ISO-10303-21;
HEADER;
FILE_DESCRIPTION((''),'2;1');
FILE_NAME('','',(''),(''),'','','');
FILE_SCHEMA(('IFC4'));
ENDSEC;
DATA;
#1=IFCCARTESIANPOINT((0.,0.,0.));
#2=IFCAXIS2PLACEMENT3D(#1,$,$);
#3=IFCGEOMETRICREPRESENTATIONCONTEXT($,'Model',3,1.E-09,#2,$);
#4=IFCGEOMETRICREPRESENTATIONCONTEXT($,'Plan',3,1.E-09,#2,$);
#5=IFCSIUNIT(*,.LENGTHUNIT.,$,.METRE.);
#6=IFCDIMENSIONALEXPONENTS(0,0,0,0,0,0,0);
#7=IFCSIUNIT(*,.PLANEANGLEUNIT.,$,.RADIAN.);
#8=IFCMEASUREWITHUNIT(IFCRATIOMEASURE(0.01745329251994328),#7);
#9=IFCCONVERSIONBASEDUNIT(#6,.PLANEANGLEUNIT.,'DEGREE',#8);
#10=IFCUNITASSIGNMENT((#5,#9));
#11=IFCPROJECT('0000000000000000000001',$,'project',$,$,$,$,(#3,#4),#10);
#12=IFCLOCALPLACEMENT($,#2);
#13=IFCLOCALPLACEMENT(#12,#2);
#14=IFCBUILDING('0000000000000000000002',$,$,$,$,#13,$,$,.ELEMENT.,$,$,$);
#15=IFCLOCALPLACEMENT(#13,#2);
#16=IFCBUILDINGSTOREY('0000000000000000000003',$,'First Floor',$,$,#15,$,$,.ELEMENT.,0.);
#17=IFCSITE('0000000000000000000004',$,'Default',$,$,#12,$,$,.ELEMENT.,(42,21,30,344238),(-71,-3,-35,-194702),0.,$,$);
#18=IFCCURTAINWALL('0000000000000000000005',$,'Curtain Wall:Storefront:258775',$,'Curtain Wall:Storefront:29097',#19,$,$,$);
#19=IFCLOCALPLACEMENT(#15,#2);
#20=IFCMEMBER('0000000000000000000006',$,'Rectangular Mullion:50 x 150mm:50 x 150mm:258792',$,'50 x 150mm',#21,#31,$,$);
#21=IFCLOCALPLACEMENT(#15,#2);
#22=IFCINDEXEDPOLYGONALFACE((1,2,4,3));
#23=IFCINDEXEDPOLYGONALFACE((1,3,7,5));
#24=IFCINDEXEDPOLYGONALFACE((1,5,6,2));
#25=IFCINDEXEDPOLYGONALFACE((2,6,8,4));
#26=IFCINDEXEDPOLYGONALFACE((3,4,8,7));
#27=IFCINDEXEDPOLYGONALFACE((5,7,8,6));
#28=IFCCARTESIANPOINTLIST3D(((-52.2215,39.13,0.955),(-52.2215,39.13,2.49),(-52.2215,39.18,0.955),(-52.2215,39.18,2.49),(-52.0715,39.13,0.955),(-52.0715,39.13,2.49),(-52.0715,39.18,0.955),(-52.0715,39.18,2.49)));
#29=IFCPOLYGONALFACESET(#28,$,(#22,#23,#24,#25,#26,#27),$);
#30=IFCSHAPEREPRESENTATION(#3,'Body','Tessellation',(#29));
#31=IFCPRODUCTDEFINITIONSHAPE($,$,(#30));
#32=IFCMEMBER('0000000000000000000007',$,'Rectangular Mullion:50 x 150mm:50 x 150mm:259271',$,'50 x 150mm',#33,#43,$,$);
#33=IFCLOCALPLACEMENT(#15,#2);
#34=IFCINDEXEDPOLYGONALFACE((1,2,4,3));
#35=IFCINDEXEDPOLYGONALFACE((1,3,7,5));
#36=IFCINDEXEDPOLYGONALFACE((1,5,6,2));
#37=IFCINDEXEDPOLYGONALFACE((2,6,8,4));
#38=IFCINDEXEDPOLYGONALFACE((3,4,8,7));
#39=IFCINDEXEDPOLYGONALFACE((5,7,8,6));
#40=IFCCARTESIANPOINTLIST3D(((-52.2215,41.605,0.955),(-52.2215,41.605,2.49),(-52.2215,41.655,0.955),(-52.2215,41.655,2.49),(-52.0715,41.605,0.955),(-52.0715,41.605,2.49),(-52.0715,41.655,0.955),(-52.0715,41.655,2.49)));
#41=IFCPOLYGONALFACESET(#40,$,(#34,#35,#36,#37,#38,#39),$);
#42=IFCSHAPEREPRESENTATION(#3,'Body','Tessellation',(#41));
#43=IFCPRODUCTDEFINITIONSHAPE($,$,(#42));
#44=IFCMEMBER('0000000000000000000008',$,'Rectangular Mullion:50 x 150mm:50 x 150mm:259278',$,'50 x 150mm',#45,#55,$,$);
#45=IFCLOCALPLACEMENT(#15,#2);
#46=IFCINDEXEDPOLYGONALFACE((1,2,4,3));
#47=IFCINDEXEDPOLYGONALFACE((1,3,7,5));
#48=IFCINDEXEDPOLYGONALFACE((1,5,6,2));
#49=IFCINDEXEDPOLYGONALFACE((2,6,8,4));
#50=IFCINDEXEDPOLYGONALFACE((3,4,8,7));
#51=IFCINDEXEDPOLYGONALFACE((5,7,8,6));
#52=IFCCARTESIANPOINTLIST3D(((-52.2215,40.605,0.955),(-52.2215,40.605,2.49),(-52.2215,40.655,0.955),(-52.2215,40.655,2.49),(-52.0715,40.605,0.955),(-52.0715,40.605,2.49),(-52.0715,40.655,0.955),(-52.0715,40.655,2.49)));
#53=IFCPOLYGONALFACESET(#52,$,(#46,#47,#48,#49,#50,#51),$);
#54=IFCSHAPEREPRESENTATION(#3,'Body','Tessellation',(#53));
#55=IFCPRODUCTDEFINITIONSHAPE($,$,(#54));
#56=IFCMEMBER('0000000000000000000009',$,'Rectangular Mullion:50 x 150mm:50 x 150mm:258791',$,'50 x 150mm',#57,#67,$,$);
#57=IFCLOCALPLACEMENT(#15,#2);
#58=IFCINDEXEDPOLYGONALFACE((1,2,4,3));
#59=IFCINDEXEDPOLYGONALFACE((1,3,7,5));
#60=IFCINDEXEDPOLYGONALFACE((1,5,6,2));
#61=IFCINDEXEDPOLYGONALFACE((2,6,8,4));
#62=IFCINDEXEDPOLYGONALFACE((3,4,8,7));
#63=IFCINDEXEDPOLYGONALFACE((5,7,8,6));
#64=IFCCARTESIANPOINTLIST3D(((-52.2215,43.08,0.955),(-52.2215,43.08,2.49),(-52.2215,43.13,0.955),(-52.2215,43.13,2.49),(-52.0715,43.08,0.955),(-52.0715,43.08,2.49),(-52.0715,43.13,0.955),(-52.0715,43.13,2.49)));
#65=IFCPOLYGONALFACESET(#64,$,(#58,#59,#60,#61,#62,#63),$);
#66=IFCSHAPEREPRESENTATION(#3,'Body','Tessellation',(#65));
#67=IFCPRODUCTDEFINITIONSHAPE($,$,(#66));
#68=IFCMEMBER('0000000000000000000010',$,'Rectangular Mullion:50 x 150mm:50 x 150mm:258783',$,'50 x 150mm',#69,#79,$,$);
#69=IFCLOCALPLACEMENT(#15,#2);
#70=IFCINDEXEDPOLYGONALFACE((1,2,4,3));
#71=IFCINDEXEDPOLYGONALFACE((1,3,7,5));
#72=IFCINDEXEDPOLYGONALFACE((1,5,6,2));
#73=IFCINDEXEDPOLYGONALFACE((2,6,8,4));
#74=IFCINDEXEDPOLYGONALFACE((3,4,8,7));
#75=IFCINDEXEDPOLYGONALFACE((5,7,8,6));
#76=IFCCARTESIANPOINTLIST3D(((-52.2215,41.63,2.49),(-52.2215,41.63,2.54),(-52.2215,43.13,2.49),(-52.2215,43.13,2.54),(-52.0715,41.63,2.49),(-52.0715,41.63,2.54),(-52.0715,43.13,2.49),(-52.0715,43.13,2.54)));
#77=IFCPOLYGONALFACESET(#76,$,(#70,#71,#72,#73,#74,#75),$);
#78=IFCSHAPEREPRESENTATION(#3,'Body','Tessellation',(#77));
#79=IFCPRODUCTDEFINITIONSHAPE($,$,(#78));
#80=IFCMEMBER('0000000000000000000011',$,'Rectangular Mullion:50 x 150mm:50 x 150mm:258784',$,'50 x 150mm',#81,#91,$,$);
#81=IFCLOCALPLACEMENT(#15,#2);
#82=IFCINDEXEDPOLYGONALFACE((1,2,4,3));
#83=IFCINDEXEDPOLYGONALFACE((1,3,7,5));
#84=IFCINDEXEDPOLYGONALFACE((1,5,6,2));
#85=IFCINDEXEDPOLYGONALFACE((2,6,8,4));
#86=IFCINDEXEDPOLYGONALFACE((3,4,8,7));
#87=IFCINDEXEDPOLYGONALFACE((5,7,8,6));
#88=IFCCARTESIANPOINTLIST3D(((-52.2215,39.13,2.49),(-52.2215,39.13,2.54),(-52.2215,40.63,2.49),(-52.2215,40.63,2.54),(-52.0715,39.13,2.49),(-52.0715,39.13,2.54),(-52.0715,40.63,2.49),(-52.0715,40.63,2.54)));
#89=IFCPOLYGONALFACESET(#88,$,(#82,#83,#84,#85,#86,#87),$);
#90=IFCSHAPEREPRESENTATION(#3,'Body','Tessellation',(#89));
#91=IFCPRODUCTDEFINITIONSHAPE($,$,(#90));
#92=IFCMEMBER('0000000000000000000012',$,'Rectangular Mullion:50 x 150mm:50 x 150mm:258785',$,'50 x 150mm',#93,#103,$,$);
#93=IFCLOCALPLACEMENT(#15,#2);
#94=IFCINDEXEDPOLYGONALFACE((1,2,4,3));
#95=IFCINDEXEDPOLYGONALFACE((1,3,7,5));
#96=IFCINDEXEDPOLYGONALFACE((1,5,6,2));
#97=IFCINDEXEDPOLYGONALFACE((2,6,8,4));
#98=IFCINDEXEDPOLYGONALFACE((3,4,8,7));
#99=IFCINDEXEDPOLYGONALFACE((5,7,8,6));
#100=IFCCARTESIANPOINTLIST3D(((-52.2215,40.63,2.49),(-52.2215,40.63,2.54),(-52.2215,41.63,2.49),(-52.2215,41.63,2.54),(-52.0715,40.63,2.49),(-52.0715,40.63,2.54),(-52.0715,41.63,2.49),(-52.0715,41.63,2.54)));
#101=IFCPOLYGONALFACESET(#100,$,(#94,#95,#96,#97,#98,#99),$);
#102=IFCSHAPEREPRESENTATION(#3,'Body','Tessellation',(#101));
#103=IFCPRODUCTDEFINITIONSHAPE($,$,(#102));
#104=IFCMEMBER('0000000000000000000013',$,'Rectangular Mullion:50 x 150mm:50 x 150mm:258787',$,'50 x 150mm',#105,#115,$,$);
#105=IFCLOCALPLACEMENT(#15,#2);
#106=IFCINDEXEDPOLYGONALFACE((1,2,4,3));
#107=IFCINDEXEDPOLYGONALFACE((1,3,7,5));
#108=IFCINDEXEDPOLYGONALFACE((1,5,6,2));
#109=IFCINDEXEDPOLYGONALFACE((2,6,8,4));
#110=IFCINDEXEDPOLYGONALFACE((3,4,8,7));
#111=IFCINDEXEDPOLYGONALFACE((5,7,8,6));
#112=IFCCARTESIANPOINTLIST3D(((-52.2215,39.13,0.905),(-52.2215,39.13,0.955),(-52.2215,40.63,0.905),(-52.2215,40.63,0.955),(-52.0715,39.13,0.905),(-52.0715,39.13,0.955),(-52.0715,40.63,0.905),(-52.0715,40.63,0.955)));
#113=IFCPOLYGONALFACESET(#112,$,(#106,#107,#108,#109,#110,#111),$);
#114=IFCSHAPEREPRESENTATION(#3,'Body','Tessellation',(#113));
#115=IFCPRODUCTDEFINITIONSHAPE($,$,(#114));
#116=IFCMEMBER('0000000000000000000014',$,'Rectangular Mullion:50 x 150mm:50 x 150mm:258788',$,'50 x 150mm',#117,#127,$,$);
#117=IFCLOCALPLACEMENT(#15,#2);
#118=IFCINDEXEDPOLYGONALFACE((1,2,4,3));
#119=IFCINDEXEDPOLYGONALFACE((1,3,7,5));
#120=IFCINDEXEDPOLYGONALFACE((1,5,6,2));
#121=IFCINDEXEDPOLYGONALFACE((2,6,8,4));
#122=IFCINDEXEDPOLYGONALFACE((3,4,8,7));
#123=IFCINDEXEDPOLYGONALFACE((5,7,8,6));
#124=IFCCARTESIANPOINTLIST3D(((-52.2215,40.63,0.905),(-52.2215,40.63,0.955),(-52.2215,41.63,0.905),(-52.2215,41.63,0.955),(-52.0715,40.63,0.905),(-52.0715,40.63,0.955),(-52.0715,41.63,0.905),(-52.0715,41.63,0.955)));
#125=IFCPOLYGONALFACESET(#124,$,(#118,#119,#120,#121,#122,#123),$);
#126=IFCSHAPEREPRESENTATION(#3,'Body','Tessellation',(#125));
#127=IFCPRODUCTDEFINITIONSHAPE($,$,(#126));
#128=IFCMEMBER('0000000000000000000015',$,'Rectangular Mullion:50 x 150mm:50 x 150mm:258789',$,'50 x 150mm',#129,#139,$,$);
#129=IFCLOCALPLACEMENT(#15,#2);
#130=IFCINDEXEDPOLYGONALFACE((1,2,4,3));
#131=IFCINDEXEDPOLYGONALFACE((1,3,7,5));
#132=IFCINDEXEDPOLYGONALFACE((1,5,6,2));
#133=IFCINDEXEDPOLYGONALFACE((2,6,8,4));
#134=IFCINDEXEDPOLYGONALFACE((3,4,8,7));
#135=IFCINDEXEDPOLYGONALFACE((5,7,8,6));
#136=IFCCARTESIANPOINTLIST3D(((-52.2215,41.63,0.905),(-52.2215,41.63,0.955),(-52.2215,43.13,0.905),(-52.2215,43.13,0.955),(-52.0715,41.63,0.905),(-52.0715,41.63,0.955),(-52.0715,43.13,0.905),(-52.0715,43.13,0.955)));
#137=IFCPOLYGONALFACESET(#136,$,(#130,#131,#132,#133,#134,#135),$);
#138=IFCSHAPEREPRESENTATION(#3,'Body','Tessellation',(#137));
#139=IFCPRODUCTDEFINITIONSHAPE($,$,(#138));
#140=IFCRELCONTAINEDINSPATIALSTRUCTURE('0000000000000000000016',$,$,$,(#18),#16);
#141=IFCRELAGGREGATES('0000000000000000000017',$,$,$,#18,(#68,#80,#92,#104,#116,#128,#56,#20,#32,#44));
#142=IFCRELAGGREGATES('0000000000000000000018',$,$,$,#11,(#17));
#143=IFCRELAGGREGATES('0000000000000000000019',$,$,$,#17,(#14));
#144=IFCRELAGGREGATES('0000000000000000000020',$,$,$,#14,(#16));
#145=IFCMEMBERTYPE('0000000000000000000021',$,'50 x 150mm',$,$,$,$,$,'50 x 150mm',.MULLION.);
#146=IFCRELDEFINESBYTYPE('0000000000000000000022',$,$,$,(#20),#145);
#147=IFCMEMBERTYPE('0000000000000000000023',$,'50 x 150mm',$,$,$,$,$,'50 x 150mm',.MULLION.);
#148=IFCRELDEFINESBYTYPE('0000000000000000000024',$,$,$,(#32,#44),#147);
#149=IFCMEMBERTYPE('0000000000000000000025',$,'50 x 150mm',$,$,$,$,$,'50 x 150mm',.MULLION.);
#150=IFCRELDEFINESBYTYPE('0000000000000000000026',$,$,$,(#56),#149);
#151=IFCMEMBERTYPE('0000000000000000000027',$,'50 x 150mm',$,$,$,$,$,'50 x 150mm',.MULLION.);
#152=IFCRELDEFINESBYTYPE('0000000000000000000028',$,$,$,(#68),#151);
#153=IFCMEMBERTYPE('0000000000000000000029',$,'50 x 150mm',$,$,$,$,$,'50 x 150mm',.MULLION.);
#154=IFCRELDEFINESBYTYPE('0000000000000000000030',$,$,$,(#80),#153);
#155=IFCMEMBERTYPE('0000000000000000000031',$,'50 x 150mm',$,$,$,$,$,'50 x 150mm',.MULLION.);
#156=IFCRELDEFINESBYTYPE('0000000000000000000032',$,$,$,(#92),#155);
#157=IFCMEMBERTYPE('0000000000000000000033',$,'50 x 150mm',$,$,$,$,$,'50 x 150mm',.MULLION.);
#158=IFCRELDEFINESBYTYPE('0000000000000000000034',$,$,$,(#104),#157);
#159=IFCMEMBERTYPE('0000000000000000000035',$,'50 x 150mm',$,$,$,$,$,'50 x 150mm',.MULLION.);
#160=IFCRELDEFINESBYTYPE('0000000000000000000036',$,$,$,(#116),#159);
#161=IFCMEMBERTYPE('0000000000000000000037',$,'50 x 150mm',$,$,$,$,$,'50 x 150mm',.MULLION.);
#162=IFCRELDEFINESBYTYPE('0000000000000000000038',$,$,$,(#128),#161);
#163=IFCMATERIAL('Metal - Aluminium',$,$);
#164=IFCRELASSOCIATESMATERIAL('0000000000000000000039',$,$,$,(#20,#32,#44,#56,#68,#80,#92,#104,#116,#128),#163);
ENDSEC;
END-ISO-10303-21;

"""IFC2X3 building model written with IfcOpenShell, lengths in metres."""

from ifc_helpers import new_model, entity, si_unit, converted_unit, frame, origin, origin_2d_with_axis, place, context, project, spatial, rectangle, extrude, source, transform, mapped, material, type_object, type_shapes, element, aggregate, save


model = new_model("IFC2X3")

# Units and contexts
model_context = context("Model", 3, precision=1e-09, world=origin())
plan_context = context("Plan", 3, precision=1e-09, world=origin())
ifc_project = project(units=[si_unit("LENGTHUNIT", "METRE"), converted_unit("PLANEANGLEUNIT", "DEGREE", entity("IfcRatioMeasure", 0.01745329251994328), si_unit("PLANEANGLEUNIT", "RADIAN"), dimensions=[0, 0, 0, 0, 0, 0, 0])], contexts=[model_context, plan_context])

# Site, building, storey
site_placement = place(None, origin())
site = spatial("IfcSite", under=ifc_project, at=site_placement, Name="Default", CompositionType="ELEMENT", RefLatitude=(42, 21, 30, 344238), RefLongitude=(-71, -3, -35, -194702), RefElevation=0.0)
building_placement = place(site_placement, origin())
building = spatial("IfcBuilding", under=site, at=building_placement, CompositionType="ELEMENT")
storey_placement = place(building_placement, origin())
storey = spatial("IfcBuildingStorey", under=building, at=storey_placement, Name="First Floor", CompositionType="ELEMENT", Elevation=0.0)

# Curtain wall, members
curtain_wall_placement = place(storey_placement, origin())
curtain_wall = element("IfcCurtainWall", 1, at=curtain_wall_placement, inside=storey, Name="Curtain Wall:Storefront:258775", ObjectType="Curtain Wall:Storefront:29097")
ifc_material_1 = material(Name="Metal - Aluminium")
member_type_1 = type_object("IfcMemberType", Name="50 x 150mm", ElementType="50 x 150mm", PredefinedType="MULLION")
shared_shape_1 = source(origin(), model_context, "Body", "SweptSolid", [
    extrude(rectangle(XDim=0.05, YDim=0.15, at=origin_2d_with_axis()), frame((-0.025, 0.0, -1.535), z_axis=(0.0, 0.0, 1.0), x_axis=(-1.0, 0.0, 0.0)), (0.0, 0.0, 1.0), 1.535),
])
type_shapes(member_type_1, [shared_shape_1])
member_1_placement = place(storey_placement, frame((-52.1465, 39.13, 2.49), z_axis=(0.0, 0.0, 1.0), x_axis=(0.0, -1.0, 0.0)))
member_1 = element("IfcMember", 2, at=member_1_placement, type_object=member_type_1, material=ifc_material_1, Name="Rectangular Mullion:50 x 150mm:50 x 150mm:258792", ObjectType="50 x 150mm", context=model_context, shape_type="MappedRepresentation", body=[
    mapped(shared_shape_1, transform((0.0, 0.0, 0.0), scale=1.0)),
])
member_type_2 = type_object("IfcMemberType", Name="50 x 150mm", ElementType="50 x 150mm", PredefinedType="MULLION")
shared_shape_2 = source(origin(), model_context, "Body", "SweptSolid", [
    extrude(rectangle(XDim=0.05, YDim=0.15, at=origin_2d_with_axis()), frame((0.0, 0.0, -1.535), z_axis=(0.0, 0.0, 1.0), x_axis=(-1.0, 0.0, 0.0)), (0.0, 0.0, 1.0), 1.535),
])
type_shapes(member_type_2, [shared_shape_2])
member_2_placement = place(storey_placement, frame((-52.1465, 41.63, 0.955), z_axis=(0.0, 0.0, -1.0), x_axis=(0.0, 1.0, 0.0)))
member_2 = element("IfcMember", 3, at=member_2_placement, type_object=member_type_2, material=ifc_material_1, Name="Rectangular Mullion:50 x 150mm:50 x 150mm:259271", ObjectType="50 x 150mm", context=model_context, shape_type="MappedRepresentation", body=[
    mapped(shared_shape_2, transform((0.0, 0.0, 0.0), scale=1.0)),
])
member_3_placement = place(storey_placement, frame((-52.1465, 40.63, 0.955), z_axis=(0.0, 0.0, -1.0), x_axis=(0.0, 1.0, 0.0)))
member_3 = element("IfcMember", 4, at=member_3_placement, type_object=member_type_2, material=ifc_material_1, Name="Rectangular Mullion:50 x 150mm:50 x 150mm:259278", ObjectType="50 x 150mm", context=model_context, shape_type="MappedRepresentation", body=[
    mapped(shared_shape_2, transform((0.0, 0.0, 0.0), scale=1.0)),
])
member_type_3 = type_object("IfcMemberType", Name="50 x 150mm", ElementType="50 x 150mm", PredefinedType="MULLION")
shared_shape_3 = source(origin(), model_context, "Body", "SweptSolid", [
    extrude(rectangle(XDim=0.05, YDim=0.15, at=origin_2d_with_axis()), frame((-0.025, 0.0, -1.535), z_axis=(0.0, 0.0, 1.0), x_axis=(-1.0, 0.0, 0.0)), (0.0, 0.0, 1.0), 1.535),
])
type_shapes(member_type_3, [shared_shape_3])
member_4_placement = place(storey_placement, frame((-52.1465, 43.13, 0.955), z_axis=(0.0, 0.0, -1.0), x_axis=(0.0, 1.0, 0.0)))
member_4 = element("IfcMember", 5, at=member_4_placement, type_object=member_type_3, material=ifc_material_1, Name="Rectangular Mullion:50 x 150mm:50 x 150mm:258791", ObjectType="50 x 150mm", context=model_context, shape_type="MappedRepresentation", body=[
    mapped(shared_shape_3, transform((0.0, 0.0, 0.0), scale=1.0)),
])
member_type_4 = type_object("IfcMemberType", Name="50 x 150mm", ElementType="50 x 150mm", PredefinedType="MULLION")
shared_shape_4 = source(origin(), model_context, "Body", "SweptSolid", [
    extrude(rectangle(XDim=0.05, YDim=0.15, at=origin_2d_with_axis()), frame((-0.025, 0.0, -1.5), z_axis=(0.0, 0.0, 1.0), x_axis=(-1.0, 0.0, 0.0)), (0.0, 0.0, 1.0), 1.5),
])
type_shapes(member_type_4, [shared_shape_4])
member_5_placement = place(storey_placement, frame((-52.1465, 43.13, 2.54), z_axis=(0.0, 1.0, 0.0), x_axis=(0.0, 0.0, 1.0)))
member_5 = element("IfcMember", 6, at=member_5_placement, type_object=member_type_4, material=ifc_material_1, Name="Rectangular Mullion:50 x 150mm:50 x 150mm:258783", ObjectType="50 x 150mm", context=model_context, shape_type="MappedRepresentation", body=[
    mapped(shared_shape_4, transform((0.0, 0.0, 0.0), scale=1.0)),
])
member_type_5 = type_object("IfcMemberType", Name="50 x 150mm", ElementType="50 x 150mm", PredefinedType="MULLION")
shared_shape_5 = source(origin(), model_context, "Body", "SweptSolid", [
    extrude(rectangle(XDim=0.05, YDim=0.15, at=origin_2d_with_axis()), frame((-0.025, 0.0, -1.5), z_axis=(0.0, 0.0, 1.0), x_axis=(-1.0, 0.0, 0.0)), (0.0, 0.0, 1.0), 1.5),
])
type_shapes(member_type_5, [shared_shape_5])
member_6_placement = place(storey_placement, frame((-52.1465, 40.63, 2.54), z_axis=(0.0, 1.0, 0.0), x_axis=(0.0, 0.0, 1.0)))
member_6 = element("IfcMember", 7, at=member_6_placement, type_object=member_type_5, material=ifc_material_1, Name="Rectangular Mullion:50 x 150mm:50 x 150mm:258784", ObjectType="50 x 150mm", context=model_context, shape_type="MappedRepresentation", body=[
    mapped(shared_shape_5, transform((0.0, 0.0, 0.0), scale=1.0)),
])
member_type_6 = type_object("IfcMemberType", Name="50 x 150mm", ElementType="50 x 150mm", PredefinedType="MULLION")
shared_shape_6 = source(origin(), model_context, "Body", "SweptSolid", [
    extrude(rectangle(XDim=0.05, YDim=0.15, at=origin_2d_with_axis()), frame((-0.025, 0.0, -1.0), z_axis=(0.0, 0.0, 1.0), x_axis=(-1.0, 0.0, 0.0)), (0.0, 0.0, 1.0), 1.0),
])
type_shapes(member_type_6, [shared_shape_6])
member_7_placement = place(storey_placement, frame((-52.1465, 41.63, 2.54), z_axis=(0.0, 1.0, 0.0), x_axis=(0.0, 0.0, 1.0)))
member_7 = element("IfcMember", 8, at=member_7_placement, type_object=member_type_6, material=ifc_material_1, Name="Rectangular Mullion:50 x 150mm:50 x 150mm:258785", ObjectType="50 x 150mm", context=model_context, shape_type="MappedRepresentation", body=[
    mapped(shared_shape_6, transform((0.0, 0.0, 0.0), scale=1.0)),
])
member_type_7 = type_object("IfcMemberType", Name="50 x 150mm", ElementType="50 x 150mm", PredefinedType="MULLION")
shared_shape_7 = source(origin(), model_context, "Body", "SweptSolid", [
    extrude(rectangle(XDim=0.05, YDim=0.15, at=origin_2d_with_axis()), frame((-0.025, 0.0, -1.5), z_axis=(0.0, 0.0, 1.0), x_axis=(-1.0, 0.0, 0.0)), (0.0, 0.0, 1.0), 1.5),
])
type_shapes(member_type_7, [shared_shape_7])
member_8_placement = place(storey_placement, frame((-52.1465, 39.13, 0.905), z_axis=(0.0, -1.0, 0.0), x_axis=(0.0, 0.0, -1.0)))
member_8 = element("IfcMember", 9, at=member_8_placement, type_object=member_type_7, material=ifc_material_1, Name="Rectangular Mullion:50 x 150mm:50 x 150mm:258787", ObjectType="50 x 150mm", context=model_context, shape_type="MappedRepresentation", body=[
    mapped(shared_shape_7, transform((0.0, 0.0, 0.0), scale=1.0)),
])
member_type_8 = type_object("IfcMemberType", Name="50 x 150mm", ElementType="50 x 150mm", PredefinedType="MULLION")
shared_shape_8 = source(origin(), model_context, "Body", "SweptSolid", [
    extrude(rectangle(XDim=0.05, YDim=0.15, at=origin_2d_with_axis()), frame((-0.025, 0.0, -1.0), z_axis=(0.0, 0.0, 1.0), x_axis=(-1.0, 0.0, 0.0)), (0.0, 0.0, 1.0), 1.0),
])
type_shapes(member_type_8, [shared_shape_8])
member_9_placement = place(storey_placement, frame((-52.1465, 40.63, 0.905), z_axis=(0.0, -1.0, 0.0), x_axis=(0.0, 0.0, -1.0)))
member_9 = element("IfcMember", 10, at=member_9_placement, type_object=member_type_8, material=ifc_material_1, Name="Rectangular Mullion:50 x 150mm:50 x 150mm:258788", ObjectType="50 x 150mm", context=model_context, shape_type="MappedRepresentation", body=[
    mapped(shared_shape_8, transform((0.0, 0.0, 0.0), scale=1.0)),
])
member_type_9 = type_object("IfcMemberType", Name="50 x 150mm", ElementType="50 x 150mm", PredefinedType="MULLION")
shared_shape_9 = source(origin(), model_context, "Body", "SweptSolid", [
    extrude(rectangle(XDim=0.05, YDim=0.15, at=origin_2d_with_axis()), frame((-0.025, 0.0, -1.5), z_axis=(0.0, 0.0, 1.0), x_axis=(-1.0, 0.0, 0.0)), (0.0, 0.0, 1.0), 1.5),
])
type_shapes(member_type_9, [shared_shape_9])
member_10_placement = place(storey_placement, frame((-52.1465, 41.63, 0.905), z_axis=(0.0, -1.0, 0.0), x_axis=(0.0, 0.0, -1.0)))
member_10 = element("IfcMember", 11, at=member_10_placement, type_object=member_type_9, material=ifc_material_1, Name="Rectangular Mullion:50 x 150mm:50 x 150mm:258789", ObjectType="50 x 150mm", context=model_context, shape_type="MappedRepresentation", body=[
    mapped(shared_shape_9, transform((0.0, 0.0, 0.0), scale=1.0)),
])
aggregate(curtain_wall, [member_5, member_6, member_7, member_8, member_9, member_10, member_4, member_1, member_2, member_3])

save(model, "model.ifc")
